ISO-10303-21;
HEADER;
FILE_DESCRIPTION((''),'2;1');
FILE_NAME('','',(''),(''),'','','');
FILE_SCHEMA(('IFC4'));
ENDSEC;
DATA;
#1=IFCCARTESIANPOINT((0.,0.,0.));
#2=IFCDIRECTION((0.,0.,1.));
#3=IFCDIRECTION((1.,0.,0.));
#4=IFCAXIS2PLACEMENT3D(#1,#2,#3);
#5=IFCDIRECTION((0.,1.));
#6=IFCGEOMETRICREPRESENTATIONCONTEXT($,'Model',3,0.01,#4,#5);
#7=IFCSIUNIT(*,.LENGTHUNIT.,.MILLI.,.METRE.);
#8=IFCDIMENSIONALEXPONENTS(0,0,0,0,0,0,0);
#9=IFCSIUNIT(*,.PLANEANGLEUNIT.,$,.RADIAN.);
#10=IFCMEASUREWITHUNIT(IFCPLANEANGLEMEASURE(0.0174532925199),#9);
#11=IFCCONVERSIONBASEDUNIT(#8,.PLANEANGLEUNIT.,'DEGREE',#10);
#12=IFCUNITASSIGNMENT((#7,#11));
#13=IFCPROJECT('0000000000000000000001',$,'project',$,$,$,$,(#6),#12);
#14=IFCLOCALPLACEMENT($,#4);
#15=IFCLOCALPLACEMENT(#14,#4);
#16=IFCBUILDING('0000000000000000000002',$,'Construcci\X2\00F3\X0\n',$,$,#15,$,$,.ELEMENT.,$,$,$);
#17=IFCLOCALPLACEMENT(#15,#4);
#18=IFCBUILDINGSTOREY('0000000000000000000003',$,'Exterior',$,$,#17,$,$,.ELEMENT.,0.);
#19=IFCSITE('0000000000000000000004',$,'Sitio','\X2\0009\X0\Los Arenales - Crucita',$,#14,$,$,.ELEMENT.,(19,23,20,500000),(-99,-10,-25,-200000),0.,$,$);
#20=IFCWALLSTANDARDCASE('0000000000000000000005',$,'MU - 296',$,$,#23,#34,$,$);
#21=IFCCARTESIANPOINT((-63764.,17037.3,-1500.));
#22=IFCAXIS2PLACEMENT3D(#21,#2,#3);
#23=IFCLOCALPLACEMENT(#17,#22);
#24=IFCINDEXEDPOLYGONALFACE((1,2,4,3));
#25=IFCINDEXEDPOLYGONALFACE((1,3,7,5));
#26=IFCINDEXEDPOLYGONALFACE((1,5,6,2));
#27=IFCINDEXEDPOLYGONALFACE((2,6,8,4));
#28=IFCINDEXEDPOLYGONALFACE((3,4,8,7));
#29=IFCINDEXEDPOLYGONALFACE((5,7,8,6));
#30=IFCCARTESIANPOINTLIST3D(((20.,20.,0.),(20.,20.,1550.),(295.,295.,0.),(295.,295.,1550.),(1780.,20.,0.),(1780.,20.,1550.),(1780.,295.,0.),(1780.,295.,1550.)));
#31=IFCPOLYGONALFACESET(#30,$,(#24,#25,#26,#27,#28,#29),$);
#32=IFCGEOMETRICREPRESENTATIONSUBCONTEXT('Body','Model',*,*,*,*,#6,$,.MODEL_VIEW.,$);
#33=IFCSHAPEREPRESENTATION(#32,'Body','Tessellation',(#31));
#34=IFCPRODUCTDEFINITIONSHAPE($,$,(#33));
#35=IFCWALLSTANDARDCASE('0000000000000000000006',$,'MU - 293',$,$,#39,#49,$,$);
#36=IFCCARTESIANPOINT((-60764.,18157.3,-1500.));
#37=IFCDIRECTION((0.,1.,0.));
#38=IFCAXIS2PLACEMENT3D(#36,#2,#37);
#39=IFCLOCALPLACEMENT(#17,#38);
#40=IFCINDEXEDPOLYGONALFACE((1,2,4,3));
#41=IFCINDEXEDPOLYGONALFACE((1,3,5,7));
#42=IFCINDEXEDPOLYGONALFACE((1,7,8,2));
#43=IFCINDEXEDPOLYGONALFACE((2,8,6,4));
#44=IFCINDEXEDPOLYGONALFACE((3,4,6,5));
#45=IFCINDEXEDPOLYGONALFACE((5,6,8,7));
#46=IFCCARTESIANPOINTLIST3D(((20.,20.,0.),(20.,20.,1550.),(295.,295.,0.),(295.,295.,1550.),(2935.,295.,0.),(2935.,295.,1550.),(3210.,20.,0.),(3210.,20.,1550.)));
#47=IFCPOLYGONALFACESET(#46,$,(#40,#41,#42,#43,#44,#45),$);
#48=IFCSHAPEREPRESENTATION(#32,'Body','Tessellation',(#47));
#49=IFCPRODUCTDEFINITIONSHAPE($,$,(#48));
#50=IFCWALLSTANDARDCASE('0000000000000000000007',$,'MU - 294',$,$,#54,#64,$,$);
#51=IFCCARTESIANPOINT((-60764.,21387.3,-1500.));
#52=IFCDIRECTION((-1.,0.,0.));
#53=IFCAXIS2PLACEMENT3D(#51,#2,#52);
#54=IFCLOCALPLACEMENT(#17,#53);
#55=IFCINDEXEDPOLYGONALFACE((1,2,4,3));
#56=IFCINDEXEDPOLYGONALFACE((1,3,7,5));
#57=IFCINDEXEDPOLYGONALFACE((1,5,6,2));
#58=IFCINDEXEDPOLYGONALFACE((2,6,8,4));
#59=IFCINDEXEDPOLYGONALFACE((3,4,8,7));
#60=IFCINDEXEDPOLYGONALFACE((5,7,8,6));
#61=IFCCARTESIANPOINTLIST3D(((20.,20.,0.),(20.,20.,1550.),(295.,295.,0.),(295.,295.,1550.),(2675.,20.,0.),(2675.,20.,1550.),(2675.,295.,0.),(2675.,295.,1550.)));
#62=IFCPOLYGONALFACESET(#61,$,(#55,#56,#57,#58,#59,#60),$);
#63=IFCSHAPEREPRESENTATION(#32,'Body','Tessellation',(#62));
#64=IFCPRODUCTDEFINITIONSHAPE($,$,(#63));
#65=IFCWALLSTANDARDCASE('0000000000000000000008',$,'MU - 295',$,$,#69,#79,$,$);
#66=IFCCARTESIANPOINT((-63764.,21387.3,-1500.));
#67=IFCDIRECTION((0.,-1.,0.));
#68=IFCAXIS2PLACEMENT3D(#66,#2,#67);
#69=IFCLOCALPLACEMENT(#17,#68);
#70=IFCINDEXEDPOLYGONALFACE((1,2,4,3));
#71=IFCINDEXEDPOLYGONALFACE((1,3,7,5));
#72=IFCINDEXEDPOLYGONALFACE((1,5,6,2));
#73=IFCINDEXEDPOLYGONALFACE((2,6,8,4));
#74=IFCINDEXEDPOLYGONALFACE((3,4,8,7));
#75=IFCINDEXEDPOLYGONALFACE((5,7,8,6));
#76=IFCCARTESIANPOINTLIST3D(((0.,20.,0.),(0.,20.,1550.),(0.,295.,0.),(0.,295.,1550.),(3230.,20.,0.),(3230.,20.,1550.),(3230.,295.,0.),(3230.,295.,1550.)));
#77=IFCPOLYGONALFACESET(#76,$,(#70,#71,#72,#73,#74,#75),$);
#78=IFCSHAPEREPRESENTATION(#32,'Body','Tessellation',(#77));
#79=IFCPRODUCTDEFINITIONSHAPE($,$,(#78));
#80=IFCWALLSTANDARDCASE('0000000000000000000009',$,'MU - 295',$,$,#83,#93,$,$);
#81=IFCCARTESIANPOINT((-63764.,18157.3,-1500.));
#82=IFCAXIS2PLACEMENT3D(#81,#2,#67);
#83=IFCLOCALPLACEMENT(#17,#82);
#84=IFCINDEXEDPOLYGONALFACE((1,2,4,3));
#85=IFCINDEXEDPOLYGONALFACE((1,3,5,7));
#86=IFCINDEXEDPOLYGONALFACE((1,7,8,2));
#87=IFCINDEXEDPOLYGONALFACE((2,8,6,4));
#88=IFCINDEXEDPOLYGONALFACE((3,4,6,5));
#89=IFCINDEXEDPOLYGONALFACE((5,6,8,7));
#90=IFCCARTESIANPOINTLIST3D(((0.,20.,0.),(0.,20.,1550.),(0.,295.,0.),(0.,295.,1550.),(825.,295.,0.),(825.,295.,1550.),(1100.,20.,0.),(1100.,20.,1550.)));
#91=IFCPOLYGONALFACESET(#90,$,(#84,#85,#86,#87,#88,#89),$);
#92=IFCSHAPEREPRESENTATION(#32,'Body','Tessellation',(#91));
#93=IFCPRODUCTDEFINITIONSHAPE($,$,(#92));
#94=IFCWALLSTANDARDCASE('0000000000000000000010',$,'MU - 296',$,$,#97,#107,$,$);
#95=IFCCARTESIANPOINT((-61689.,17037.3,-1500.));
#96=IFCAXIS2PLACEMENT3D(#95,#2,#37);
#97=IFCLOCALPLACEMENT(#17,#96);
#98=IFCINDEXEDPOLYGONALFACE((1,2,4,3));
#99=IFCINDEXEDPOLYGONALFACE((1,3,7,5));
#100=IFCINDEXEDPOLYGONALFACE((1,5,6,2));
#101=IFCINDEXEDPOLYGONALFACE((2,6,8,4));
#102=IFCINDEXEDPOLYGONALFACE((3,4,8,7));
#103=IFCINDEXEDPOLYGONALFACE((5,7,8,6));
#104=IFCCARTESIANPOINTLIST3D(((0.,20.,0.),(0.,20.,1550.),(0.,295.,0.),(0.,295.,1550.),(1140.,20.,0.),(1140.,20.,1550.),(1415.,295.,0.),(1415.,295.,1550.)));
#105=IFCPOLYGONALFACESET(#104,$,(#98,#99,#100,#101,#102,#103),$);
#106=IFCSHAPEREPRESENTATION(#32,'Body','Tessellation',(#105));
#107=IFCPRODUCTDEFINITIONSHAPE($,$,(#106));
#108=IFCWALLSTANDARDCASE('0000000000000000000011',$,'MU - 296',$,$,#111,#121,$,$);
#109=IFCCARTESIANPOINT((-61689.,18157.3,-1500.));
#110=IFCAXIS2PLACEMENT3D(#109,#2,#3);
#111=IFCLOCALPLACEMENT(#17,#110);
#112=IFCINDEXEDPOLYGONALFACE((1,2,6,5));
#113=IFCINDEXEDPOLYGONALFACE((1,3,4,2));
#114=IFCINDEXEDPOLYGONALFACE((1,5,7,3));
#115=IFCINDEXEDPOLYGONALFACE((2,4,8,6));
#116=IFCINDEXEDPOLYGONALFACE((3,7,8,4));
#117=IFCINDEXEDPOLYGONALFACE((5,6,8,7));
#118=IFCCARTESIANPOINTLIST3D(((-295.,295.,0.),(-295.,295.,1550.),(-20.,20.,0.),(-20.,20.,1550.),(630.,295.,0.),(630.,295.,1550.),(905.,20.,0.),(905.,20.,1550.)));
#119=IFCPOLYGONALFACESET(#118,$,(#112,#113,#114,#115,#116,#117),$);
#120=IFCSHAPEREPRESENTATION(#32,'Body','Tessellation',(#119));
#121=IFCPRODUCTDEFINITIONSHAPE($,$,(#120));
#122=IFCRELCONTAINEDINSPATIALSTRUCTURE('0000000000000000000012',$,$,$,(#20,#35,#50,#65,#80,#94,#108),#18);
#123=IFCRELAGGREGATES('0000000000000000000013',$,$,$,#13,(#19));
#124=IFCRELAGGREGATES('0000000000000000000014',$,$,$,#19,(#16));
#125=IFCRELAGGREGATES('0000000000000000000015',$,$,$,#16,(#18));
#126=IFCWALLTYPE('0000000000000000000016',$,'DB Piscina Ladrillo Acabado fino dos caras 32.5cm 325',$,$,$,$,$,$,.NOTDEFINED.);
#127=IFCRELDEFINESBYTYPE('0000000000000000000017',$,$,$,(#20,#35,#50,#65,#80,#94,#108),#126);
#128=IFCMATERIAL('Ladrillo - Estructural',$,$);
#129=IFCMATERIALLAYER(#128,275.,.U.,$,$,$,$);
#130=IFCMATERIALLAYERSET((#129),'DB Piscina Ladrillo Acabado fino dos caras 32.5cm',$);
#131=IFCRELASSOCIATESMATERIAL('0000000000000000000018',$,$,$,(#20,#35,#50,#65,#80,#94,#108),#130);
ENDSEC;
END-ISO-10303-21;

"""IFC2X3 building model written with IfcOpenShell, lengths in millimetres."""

from ifc_helpers import new_model, entity, si_unit, converted_unit, direction, frame, origin_with_axes, place, context, subcontext, project, spatial, polyline, outline, extrude, material, layer, layer_set, layer_usage, type_object, element, save


model = new_model("IFC2X3")

# Units and contexts
model_context = context("Model", 3, precision=0.01, world=origin_with_axes(), true_north=direction((0.0, 1.0)))
body_context = subcontext(model_context, "Body", "Model", "MODEL_VIEW")
ifc_project = project(units=[si_unit("LENGTHUNIT", "METRE", prefix="MILLI"), converted_unit("PLANEANGLEUNIT", "DEGREE", entity("IfcPlaneAngleMeasure", 0.0174532925199), si_unit("PLANEANGLEUNIT", "RADIAN"), dimensions=[0, 0, 0, 0, 0, 0, 0])], contexts=[model_context])

# Site, building, storey
site_placement = place(None, origin_with_axes())
site = spatial("IfcSite", under=ifc_project, at=site_placement, Name="Sitio", Description="\tLos Arenales - Crucita", CompositionType="ELEMENT", RefLatitude=(19, 23, 20, 500000), RefLongitude=(-99, -10, -25, -200000), RefElevation=0.0)
building_placement = place(site_placement, origin_with_axes())
building = spatial("IfcBuilding", under=site, at=building_placement, Name="Construcción", CompositionType="ELEMENT")
storey_placement = place(building_placement, origin_with_axes())
storey = spatial("IfcBuildingStorey", under=building, at=storey_placement, Name="Exterior", CompositionType="ELEMENT", Elevation=0.0)

# Walls
ifc_material_1 = material(Name="Ladrillo - Estructural")
ifc_layer = layer(ifc_material_1, 275.0, ventilated="UNKNOWN")
ifc_layer_set = layer_set([ifc_layer], Name="DB Piscina Ladrillo Acabado fino dos caras 32.5cm")
ifc_layer_usage_1 = layer_usage(ifc_layer_set, "AXIS2", "NEGATIVE", 295.0)
wall_type = type_object("IfcWallType", Name="DB Piscina Ladrillo Acabado fino dos caras 32.5cm 325", PredefinedType="NOTDEFINED")
wall_1_placement = place(storey_placement, frame((-63764.0, 17037.3, -1500.0), z_axis=(0.0, 0.0, 1.0), x_axis=(1.0, 0.0, 0.0)))
element("IfcWallStandardCase", 1, at=wall_1_placement, inside=storey, type_object=wall_type, material=ifc_layer_usage_1, Name="MU - 296", context=body_context, shape_type="SweptSolid", body=[
    extrude(outline(polyline([(20.0, 20.0), (1780.0, 20.0), (1780.0, 295.0), (295.0, 295.0), (20.0, 20.0)])), origin_with_axes(), (0.0, 0.0, 1.0), 1550.0),
])
ifc_layer_usage_2 = layer_usage(ifc_layer_set, "AXIS2", "NEGATIVE", 295.0)
wall_2_placement = place(storey_placement, frame((-60764.0, 18157.3, -1500.0), z_axis=(0.0, 0.0, 1.0), x_axis=(0.0, 1.0, 0.0)))
element("IfcWallStandardCase", 2, at=wall_2_placement, inside=storey, type_object=wall_type, material=ifc_layer_usage_2, Name="MU - 293", context=body_context, shape_type="SweptSolid", body=[
    extrude(outline(polyline([(20.0, 20.0), (3210.0, 20.0), (2935.0, 295.0), (295.0, 295.0), (20.0, 20.0)])), origin_with_axes(), (0.0, 0.0, 1.0), 1550.0),
])
ifc_layer_usage_3 = layer_usage(ifc_layer_set, "AXIS2", "NEGATIVE", 295.0)
wall_3_placement = place(storey_placement, frame((-60764.0, 21387.3, -1500.0), z_axis=(0.0, 0.0, 1.0), x_axis=(-1.0, 0.0, 0.0)))
element("IfcWallStandardCase", 3, at=wall_3_placement, inside=storey, type_object=wall_type, material=ifc_layer_usage_3, Name="MU - 294", context=body_context, shape_type="SweptSolid", body=[
    extrude(outline(polyline([(20.0, 20.0), (2675.0, 20.0), (2675.0, 295.0), (295.0, 295.0), (20.0, 20.0)])), origin_with_axes(), (0.0, 0.0, 1.0), 1550.0),
])
ifc_layer_usage_4 = layer_usage(ifc_layer_set, "AXIS2", "NEGATIVE", 295.0)
wall_4_placement = place(storey_placement, frame((-63764.0, 21387.3, -1500.0), z_axis=(0.0, 0.0, 1.0), x_axis=(0.0, -1.0, 0.0)))
element("IfcWallStandardCase", 4, at=wall_4_placement, inside=storey, type_object=wall_type, material=ifc_layer_usage_4, Name="MU - 295", context=body_context, shape_type="SweptSolid", body=[
    extrude(outline(polyline([(0.0, 20.0), (3230.0, 20.0), (3230.0, 295.0), (0.0, 295.0), (0.0, 20.0)])), origin_with_axes(), (0.0, 0.0, 1.0), 1550.0),
])
ifc_layer_usage_5 = layer_usage(ifc_layer_set, "AXIS2", "NEGATIVE", 295.0)
wall_5_placement = place(storey_placement, frame((-63764.0, 18157.3, -1500.0), z_axis=(0.0, 0.0, 1.0), x_axis=(0.0, -1.0, 0.0)))
element("IfcWallStandardCase", 5, at=wall_5_placement, inside=storey, type_object=wall_type, material=ifc_layer_usage_5, Name="MU - 295", context=body_context, shape_type="SweptSolid", body=[
    extrude(outline(polyline([(0.0, 20.0), (1100.0, 20.0), (825.0, 295.0), (0.0, 295.0), (0.0, 20.0)])), origin_with_axes(), (0.0, 0.0, 1.0), 1550.0),
])
ifc_layer_usage_6 = layer_usage(ifc_layer_set, "AXIS2", "NEGATIVE", 295.0)
wall_6_placement = place(storey_placement, frame((-61689.0, 17037.3, -1500.0), z_axis=(0.0, 0.0, 1.0), x_axis=(0.0, 1.0, 0.0)))
element("IfcWallStandardCase", 6, at=wall_6_placement, inside=storey, type_object=wall_type, material=ifc_layer_usage_6, Name="MU - 296", context=body_context, shape_type="SweptSolid", body=[
    extrude(outline(polyline([(0.0, 20.0), (1140.0, 20.0), (1415.0, 295.0), (0.0, 295.0), (0.0, 20.0)])), origin_with_axes(), (0.0, 0.0, 1.0), 1550.0),
])
ifc_layer_usage_7 = layer_usage(ifc_layer_set, "AXIS2", "NEGATIVE", 295.0)
wall_7_placement = place(storey_placement, frame((-61689.0, 18157.3, -1500.0), z_axis=(0.0, 0.0, 1.0), x_axis=(1.0, 0.0, 0.0)))
element("IfcWallStandardCase", 7, at=wall_7_placement, inside=storey, type_object=wall_type, material=ifc_layer_usage_7, Name="MU - 296", context=body_context, shape_type="SweptSolid", body=[
    extrude(outline(polyline([(-20.0, 20.0), (905.0, 20.0), (630.0, 295.0), (-295.0, 295.0), (-20.0, 20.0)])), origin_with_axes(), (0.0, 0.0, 1.0), 1550.0),
])

save(model, "model.ifc")
